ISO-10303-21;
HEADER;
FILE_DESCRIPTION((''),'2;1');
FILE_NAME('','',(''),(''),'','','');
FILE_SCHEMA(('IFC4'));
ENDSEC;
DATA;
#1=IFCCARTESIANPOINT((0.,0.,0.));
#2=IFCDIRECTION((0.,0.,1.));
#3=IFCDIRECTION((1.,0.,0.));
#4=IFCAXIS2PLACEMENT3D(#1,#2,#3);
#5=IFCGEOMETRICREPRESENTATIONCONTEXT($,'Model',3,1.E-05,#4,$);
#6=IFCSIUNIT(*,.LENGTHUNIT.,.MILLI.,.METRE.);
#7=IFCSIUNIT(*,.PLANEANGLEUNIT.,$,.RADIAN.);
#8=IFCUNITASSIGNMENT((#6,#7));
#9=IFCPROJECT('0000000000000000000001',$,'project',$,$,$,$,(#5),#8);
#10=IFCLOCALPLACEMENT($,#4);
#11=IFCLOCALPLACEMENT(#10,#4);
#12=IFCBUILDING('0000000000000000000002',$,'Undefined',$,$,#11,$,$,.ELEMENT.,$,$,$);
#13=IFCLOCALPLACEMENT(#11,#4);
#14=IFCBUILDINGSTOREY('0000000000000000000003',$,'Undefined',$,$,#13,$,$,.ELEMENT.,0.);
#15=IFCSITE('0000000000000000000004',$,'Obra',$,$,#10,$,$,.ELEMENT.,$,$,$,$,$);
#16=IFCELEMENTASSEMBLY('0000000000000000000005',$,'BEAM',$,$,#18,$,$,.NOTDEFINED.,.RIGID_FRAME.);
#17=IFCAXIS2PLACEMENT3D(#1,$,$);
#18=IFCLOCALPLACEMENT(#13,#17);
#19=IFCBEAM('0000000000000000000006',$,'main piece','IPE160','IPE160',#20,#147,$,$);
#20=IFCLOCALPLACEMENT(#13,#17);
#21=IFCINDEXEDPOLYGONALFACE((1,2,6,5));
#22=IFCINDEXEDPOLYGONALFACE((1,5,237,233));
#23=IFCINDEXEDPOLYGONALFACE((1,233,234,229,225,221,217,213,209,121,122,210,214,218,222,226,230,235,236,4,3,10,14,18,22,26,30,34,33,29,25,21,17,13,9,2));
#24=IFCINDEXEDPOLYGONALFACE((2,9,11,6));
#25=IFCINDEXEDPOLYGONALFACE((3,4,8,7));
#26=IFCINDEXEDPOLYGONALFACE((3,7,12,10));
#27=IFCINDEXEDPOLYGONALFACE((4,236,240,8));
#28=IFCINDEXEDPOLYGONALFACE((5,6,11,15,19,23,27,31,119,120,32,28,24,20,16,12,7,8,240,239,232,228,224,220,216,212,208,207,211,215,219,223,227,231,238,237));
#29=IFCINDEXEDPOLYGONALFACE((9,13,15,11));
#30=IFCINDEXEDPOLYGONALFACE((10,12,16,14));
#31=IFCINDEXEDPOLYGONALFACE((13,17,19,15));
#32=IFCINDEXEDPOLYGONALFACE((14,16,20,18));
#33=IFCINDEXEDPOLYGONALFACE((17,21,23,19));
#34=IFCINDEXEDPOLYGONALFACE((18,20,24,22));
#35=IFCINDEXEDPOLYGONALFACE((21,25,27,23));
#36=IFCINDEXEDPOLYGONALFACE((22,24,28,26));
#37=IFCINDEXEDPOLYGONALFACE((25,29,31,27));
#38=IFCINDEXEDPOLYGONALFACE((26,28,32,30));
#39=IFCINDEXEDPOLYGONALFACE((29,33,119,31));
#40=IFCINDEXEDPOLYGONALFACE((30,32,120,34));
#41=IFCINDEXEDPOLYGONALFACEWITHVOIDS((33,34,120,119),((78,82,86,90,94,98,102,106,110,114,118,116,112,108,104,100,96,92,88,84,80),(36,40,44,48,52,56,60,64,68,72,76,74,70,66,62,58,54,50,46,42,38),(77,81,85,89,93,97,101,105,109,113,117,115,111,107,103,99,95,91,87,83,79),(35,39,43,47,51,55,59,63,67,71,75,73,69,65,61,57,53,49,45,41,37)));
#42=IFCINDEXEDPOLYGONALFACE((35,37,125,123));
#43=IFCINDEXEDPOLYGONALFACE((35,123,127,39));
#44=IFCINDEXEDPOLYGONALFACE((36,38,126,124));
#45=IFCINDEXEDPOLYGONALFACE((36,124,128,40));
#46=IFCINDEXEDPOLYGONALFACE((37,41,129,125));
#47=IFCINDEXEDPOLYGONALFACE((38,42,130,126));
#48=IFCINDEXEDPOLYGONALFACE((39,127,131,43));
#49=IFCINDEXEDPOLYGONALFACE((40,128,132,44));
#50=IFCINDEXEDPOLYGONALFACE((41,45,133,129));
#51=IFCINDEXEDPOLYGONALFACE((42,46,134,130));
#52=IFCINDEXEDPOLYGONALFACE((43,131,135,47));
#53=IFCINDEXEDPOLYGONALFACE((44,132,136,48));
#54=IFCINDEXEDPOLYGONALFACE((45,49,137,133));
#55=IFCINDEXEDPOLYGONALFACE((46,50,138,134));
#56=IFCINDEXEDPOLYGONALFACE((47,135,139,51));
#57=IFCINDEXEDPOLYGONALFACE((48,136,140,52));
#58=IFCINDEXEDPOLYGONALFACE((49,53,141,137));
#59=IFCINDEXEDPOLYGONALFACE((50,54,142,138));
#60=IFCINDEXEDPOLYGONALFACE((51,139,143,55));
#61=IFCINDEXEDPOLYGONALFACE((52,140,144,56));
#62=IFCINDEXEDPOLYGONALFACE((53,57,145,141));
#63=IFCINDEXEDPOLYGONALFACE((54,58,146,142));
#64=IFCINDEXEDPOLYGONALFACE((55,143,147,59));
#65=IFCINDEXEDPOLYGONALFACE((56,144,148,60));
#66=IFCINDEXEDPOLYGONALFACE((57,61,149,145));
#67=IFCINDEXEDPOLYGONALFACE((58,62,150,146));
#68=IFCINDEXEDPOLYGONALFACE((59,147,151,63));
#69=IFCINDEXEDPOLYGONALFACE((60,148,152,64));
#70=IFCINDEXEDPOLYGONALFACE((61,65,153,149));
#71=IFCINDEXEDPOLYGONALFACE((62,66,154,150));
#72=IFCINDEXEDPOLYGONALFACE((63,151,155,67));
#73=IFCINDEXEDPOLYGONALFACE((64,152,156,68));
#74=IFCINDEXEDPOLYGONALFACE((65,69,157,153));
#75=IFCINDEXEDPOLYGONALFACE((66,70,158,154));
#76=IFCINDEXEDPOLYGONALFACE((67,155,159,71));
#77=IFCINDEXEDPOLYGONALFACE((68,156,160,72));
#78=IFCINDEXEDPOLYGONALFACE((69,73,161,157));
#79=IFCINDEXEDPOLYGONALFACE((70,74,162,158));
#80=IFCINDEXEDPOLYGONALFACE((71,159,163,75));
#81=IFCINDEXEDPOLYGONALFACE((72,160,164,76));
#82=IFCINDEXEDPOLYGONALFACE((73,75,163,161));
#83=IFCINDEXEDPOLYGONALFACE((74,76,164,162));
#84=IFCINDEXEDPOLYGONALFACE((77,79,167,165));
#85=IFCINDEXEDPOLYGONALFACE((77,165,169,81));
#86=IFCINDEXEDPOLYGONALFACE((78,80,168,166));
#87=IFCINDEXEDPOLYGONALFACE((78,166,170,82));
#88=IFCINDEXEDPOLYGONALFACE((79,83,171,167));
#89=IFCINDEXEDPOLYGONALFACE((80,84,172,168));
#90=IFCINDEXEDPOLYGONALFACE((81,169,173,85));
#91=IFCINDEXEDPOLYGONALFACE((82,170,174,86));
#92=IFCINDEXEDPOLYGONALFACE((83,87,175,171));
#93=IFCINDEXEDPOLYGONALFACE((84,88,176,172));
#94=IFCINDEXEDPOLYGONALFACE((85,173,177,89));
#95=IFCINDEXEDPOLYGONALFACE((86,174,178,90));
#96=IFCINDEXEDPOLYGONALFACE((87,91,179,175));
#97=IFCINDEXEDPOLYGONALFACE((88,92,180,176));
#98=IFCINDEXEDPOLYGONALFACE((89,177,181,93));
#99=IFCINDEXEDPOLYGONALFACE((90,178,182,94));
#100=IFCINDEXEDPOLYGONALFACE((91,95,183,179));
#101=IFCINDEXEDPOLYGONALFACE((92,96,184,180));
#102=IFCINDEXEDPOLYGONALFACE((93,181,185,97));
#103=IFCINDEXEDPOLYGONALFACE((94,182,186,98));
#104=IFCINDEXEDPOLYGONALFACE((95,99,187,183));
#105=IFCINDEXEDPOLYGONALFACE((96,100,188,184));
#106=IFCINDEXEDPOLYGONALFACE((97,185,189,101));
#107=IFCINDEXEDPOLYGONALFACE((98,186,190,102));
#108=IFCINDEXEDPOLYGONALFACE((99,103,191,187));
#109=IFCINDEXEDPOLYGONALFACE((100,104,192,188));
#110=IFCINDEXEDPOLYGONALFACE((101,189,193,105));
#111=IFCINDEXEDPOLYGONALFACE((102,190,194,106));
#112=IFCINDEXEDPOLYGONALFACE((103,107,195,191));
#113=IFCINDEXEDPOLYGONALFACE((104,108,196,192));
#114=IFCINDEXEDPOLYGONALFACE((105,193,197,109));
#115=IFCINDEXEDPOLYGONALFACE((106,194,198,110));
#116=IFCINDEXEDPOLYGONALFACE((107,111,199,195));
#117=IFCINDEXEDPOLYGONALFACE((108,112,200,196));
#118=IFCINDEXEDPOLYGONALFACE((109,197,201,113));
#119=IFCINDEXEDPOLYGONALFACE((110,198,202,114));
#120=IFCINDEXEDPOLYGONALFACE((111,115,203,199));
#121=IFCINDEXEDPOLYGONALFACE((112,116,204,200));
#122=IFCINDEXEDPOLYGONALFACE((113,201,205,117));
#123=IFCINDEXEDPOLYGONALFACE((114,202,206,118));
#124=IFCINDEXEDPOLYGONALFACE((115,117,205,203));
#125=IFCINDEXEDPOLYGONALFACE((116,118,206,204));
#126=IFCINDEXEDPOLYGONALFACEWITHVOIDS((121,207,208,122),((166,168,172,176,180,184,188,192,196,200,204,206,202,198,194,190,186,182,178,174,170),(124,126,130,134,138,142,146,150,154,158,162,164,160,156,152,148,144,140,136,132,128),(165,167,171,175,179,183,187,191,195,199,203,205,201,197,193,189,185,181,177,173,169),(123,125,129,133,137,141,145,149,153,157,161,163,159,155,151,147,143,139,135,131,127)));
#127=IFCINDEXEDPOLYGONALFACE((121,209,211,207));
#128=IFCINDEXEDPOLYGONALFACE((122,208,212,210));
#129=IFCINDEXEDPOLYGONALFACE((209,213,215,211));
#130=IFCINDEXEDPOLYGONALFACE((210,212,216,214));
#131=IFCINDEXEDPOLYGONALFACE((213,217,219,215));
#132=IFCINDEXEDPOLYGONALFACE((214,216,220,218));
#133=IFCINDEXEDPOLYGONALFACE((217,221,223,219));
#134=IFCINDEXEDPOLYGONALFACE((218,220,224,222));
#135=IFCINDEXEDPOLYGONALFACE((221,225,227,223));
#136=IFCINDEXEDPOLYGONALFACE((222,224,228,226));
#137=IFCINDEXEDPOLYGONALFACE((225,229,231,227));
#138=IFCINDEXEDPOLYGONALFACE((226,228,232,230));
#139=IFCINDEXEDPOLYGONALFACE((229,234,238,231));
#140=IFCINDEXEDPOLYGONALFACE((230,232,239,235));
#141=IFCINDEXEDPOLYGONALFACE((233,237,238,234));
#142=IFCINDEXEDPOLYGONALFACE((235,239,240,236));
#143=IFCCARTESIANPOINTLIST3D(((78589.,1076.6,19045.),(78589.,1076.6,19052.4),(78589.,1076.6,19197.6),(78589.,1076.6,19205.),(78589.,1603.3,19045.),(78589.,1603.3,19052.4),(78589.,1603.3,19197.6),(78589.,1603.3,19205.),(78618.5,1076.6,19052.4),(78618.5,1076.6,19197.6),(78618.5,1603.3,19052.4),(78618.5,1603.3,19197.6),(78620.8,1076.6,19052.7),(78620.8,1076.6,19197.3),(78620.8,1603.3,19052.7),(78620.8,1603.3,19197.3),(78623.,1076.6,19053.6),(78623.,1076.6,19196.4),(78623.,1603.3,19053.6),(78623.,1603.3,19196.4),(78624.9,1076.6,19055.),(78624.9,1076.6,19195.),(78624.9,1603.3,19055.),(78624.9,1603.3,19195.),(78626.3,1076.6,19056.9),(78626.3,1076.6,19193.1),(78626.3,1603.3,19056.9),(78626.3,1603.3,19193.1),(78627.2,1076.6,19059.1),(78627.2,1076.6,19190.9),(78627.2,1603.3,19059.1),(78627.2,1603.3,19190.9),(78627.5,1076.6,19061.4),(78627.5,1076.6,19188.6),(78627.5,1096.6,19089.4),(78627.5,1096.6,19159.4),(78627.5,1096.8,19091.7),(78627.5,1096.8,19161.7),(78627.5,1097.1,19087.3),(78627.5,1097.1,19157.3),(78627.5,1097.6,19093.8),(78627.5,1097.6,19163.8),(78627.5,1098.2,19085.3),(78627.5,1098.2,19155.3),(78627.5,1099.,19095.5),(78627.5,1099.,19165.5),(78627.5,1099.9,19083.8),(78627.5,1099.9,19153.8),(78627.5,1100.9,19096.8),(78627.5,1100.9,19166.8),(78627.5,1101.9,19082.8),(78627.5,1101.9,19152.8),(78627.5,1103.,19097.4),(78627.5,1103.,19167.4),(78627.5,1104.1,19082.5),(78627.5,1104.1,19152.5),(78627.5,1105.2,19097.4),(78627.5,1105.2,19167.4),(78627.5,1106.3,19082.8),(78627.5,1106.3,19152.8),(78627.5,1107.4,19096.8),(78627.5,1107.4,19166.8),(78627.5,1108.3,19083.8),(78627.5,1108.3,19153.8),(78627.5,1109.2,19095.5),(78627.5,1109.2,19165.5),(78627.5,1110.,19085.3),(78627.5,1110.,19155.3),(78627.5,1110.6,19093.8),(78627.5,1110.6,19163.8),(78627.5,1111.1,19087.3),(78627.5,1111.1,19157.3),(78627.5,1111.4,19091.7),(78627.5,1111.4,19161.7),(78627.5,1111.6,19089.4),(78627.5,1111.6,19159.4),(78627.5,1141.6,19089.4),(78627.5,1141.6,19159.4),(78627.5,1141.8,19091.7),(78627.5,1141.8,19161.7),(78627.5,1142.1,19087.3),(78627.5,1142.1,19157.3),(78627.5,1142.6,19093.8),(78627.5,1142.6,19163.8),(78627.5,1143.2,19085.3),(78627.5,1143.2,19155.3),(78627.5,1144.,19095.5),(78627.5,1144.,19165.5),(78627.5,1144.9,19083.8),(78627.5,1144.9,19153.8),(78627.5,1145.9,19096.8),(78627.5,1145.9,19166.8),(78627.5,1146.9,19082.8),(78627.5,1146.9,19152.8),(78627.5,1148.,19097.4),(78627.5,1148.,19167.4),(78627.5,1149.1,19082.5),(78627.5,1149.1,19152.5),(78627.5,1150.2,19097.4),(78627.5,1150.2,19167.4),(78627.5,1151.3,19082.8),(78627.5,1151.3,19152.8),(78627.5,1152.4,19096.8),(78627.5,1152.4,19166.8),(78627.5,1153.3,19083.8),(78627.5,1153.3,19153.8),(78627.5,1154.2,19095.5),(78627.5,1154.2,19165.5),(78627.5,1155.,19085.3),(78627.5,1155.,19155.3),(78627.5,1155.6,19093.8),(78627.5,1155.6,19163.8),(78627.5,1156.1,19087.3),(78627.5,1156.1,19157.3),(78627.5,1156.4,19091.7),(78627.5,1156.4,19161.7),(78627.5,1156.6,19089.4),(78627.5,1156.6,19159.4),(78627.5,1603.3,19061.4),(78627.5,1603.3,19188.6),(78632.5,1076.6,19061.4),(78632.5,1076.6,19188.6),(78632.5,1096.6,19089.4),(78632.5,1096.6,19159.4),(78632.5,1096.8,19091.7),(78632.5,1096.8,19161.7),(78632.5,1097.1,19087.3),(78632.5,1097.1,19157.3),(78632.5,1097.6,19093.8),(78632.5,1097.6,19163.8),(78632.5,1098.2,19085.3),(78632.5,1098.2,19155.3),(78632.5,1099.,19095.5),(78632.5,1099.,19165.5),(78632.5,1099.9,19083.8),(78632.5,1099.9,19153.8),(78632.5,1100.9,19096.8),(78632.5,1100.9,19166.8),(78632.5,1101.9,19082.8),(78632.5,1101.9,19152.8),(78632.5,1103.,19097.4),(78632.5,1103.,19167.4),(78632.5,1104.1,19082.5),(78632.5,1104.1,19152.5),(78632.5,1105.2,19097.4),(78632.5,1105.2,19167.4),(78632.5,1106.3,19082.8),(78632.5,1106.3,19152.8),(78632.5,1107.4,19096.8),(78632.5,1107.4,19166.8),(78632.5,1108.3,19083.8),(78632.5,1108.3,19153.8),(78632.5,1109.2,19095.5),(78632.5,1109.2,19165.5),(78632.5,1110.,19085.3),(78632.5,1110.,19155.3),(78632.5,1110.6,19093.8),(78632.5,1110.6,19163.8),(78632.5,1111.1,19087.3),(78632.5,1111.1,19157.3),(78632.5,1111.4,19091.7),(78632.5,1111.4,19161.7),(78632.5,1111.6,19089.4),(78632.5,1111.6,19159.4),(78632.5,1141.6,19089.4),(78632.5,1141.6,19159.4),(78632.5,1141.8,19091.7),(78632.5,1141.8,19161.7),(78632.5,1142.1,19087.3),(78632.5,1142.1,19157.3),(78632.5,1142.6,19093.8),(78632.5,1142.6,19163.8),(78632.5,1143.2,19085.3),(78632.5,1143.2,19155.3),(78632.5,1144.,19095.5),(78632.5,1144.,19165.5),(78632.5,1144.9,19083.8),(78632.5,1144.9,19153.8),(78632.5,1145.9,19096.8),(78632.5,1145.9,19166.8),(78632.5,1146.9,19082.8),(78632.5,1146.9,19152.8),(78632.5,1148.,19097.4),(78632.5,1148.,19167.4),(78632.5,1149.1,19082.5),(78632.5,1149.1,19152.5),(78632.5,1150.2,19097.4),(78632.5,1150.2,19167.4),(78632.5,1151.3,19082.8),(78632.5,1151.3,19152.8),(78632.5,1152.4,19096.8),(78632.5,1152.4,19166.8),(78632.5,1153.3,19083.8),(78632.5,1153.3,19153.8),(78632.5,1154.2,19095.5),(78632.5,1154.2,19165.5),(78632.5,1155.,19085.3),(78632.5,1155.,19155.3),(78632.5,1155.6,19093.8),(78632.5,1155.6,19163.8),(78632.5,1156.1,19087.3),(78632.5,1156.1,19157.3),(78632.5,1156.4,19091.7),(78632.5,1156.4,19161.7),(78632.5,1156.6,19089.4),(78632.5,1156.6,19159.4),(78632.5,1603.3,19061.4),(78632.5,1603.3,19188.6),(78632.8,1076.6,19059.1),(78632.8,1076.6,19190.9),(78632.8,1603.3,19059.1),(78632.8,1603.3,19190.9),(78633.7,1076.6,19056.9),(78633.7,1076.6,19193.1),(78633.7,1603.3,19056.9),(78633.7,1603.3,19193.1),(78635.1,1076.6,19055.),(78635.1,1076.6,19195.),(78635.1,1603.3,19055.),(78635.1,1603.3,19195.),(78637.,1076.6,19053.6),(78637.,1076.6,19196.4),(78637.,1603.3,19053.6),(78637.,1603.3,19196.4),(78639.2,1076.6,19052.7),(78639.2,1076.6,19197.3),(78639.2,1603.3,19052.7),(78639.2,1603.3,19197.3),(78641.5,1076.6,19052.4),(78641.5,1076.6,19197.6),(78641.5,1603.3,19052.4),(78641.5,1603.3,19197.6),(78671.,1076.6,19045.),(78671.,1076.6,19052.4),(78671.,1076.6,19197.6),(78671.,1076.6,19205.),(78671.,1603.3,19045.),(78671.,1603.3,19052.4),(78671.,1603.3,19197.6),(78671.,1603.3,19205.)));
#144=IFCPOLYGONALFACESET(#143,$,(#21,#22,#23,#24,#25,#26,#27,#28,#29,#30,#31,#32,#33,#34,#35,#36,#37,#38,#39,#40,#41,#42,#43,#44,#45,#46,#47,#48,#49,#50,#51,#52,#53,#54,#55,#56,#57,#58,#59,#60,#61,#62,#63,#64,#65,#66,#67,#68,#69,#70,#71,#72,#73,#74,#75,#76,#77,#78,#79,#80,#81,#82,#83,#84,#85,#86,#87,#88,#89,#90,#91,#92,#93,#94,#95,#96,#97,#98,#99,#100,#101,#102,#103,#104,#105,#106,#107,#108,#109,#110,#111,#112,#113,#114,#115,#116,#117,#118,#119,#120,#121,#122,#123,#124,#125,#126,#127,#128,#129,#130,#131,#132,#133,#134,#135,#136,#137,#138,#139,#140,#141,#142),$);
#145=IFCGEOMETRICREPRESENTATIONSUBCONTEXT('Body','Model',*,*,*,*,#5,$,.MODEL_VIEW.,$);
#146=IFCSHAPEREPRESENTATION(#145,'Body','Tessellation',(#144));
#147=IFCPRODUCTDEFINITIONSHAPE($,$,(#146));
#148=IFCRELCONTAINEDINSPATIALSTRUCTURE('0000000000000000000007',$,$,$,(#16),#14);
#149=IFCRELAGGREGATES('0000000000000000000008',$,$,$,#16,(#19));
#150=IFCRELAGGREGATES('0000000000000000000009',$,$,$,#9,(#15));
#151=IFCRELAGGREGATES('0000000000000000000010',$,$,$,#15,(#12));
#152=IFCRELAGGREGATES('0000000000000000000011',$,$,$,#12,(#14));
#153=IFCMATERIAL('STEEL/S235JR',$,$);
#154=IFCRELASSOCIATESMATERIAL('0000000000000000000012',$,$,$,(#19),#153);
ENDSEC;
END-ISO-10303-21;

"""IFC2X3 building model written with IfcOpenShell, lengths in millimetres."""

from ifc_helpers import new_model, si_unit, frame, origin_with_axes, origin_2d_with_axis, place, context, subcontext, project, spatial, circle, i_section, extrude, clip, halfspace, source, transform, mapped, material, element, aggregate, save


model = new_model("IFC2X3")

# Units and contexts
model_context = context("Model", 3, precision=1e-05, world=origin_with_axes())
body_context = subcontext(model_context, "Body", "Model", "MODEL_VIEW")
ifc_project = project(units=[si_unit("LENGTHUNIT", "METRE", prefix="MILLI"), si_unit("PLANEANGLEUNIT", "RADIAN")], contexts=[model_context])

# Site, building, storey
site_placement = place(None, origin_with_axes())
site = spatial("IfcSite", under=ifc_project, at=site_placement, Name="Obra", CompositionType="ELEMENT")
building_placement = place(site_placement, origin_with_axes())
building = spatial("IfcBuilding", under=site, at=building_placement, Name="Undefined", CompositionType="ELEMENT")
storey_placement = place(building_placement, origin_with_axes())
storey = spatial("IfcBuildingStorey", under=building, at=storey_placement, Name="Undefined", CompositionType="ELEMENT", Elevation=0.0)

# Element assembly, beam, opening
ifc_material_1 = material(Name="STEEL/S235JR")
shared_shape_1 = source(origin_with_axes(), body_context, "Body", "SweptSolid", [
    extrude(circle(Radius=7.5, at=origin_2d_with_axis()), frame((0.0, -2.6, 0.0), z_axis=(0.0, 1.0, 0.0), x_axis=(1.0, 0.0, 0.0)), (0.0, 0.0, 1.0), 5.2),
])
assembly_1_placement = place(storey_placement, origin_with_axes())
assembly_1 = element("IfcElementAssembly", 1, at=assembly_1_placement, inside=storey, Name="BEAM", AssemblyPlace="NOTDEFINED", PredefinedType="RIGID_FRAME")
beam_1_placement = place(assembly_1_placement, frame((78630.0, 1086.6, 19125.0), z_axis=(0.0, 0.0, 1.0), x_axis=(0.0, 1.0, 0.0)))
beam_1 = element("IfcBeam", 2, at=beam_1_placement, material=ifc_material_1, Name="main piece", Description="IPE160", ObjectType="IPE160", context=body_context, shape_type="Clipping", body=[
    clip(extrude(i_section(OverallWidth=82.0, OverallDepth=160.0, WebThickness=5.0, FlangeThickness=7.4, FilletRadius=9.0, at=origin_2d_with_axis()), frame((516.7, 0.0, 0.0), z_axis=(-1.0, 0.0, 0.0), x_axis=(0.0, -1.0, 0.0)), (0.0, 0.0, 1.0), 526.7), halfspace(frame((-10.0, 0.0, -180.0), z_axis=(1.0, 0.0, 0.0), x_axis=(0.0, -1.0, 0.0)), True)),
])
opening_1_placement = place(assembly_1_placement, frame((78630.0, 1126.6, 19160.0), z_axis=(0.0, 1.0, 0.0), x_axis=(0.0, 0.0, -1.0)))
element("IfcOpeningElement", 3, at=opening_1_placement, cuts=beam_1, ObjectType="Opening", context=body_context, shape_type="MappedRepresentation", body=[
    mapped(shared_shape_1, transform((0.0, 0.0, -22.5))),
    mapped(shared_shape_1, transform((70.0, 0.0, -22.5))),
    mapped(shared_shape_1, transform((0.0, 0.0, 22.5))),
    mapped(shared_shape_1, transform((70.0, 0.0, 22.5))),
])
aggregate(assembly_1, [beam_1])

save(model, "model.ifc")
